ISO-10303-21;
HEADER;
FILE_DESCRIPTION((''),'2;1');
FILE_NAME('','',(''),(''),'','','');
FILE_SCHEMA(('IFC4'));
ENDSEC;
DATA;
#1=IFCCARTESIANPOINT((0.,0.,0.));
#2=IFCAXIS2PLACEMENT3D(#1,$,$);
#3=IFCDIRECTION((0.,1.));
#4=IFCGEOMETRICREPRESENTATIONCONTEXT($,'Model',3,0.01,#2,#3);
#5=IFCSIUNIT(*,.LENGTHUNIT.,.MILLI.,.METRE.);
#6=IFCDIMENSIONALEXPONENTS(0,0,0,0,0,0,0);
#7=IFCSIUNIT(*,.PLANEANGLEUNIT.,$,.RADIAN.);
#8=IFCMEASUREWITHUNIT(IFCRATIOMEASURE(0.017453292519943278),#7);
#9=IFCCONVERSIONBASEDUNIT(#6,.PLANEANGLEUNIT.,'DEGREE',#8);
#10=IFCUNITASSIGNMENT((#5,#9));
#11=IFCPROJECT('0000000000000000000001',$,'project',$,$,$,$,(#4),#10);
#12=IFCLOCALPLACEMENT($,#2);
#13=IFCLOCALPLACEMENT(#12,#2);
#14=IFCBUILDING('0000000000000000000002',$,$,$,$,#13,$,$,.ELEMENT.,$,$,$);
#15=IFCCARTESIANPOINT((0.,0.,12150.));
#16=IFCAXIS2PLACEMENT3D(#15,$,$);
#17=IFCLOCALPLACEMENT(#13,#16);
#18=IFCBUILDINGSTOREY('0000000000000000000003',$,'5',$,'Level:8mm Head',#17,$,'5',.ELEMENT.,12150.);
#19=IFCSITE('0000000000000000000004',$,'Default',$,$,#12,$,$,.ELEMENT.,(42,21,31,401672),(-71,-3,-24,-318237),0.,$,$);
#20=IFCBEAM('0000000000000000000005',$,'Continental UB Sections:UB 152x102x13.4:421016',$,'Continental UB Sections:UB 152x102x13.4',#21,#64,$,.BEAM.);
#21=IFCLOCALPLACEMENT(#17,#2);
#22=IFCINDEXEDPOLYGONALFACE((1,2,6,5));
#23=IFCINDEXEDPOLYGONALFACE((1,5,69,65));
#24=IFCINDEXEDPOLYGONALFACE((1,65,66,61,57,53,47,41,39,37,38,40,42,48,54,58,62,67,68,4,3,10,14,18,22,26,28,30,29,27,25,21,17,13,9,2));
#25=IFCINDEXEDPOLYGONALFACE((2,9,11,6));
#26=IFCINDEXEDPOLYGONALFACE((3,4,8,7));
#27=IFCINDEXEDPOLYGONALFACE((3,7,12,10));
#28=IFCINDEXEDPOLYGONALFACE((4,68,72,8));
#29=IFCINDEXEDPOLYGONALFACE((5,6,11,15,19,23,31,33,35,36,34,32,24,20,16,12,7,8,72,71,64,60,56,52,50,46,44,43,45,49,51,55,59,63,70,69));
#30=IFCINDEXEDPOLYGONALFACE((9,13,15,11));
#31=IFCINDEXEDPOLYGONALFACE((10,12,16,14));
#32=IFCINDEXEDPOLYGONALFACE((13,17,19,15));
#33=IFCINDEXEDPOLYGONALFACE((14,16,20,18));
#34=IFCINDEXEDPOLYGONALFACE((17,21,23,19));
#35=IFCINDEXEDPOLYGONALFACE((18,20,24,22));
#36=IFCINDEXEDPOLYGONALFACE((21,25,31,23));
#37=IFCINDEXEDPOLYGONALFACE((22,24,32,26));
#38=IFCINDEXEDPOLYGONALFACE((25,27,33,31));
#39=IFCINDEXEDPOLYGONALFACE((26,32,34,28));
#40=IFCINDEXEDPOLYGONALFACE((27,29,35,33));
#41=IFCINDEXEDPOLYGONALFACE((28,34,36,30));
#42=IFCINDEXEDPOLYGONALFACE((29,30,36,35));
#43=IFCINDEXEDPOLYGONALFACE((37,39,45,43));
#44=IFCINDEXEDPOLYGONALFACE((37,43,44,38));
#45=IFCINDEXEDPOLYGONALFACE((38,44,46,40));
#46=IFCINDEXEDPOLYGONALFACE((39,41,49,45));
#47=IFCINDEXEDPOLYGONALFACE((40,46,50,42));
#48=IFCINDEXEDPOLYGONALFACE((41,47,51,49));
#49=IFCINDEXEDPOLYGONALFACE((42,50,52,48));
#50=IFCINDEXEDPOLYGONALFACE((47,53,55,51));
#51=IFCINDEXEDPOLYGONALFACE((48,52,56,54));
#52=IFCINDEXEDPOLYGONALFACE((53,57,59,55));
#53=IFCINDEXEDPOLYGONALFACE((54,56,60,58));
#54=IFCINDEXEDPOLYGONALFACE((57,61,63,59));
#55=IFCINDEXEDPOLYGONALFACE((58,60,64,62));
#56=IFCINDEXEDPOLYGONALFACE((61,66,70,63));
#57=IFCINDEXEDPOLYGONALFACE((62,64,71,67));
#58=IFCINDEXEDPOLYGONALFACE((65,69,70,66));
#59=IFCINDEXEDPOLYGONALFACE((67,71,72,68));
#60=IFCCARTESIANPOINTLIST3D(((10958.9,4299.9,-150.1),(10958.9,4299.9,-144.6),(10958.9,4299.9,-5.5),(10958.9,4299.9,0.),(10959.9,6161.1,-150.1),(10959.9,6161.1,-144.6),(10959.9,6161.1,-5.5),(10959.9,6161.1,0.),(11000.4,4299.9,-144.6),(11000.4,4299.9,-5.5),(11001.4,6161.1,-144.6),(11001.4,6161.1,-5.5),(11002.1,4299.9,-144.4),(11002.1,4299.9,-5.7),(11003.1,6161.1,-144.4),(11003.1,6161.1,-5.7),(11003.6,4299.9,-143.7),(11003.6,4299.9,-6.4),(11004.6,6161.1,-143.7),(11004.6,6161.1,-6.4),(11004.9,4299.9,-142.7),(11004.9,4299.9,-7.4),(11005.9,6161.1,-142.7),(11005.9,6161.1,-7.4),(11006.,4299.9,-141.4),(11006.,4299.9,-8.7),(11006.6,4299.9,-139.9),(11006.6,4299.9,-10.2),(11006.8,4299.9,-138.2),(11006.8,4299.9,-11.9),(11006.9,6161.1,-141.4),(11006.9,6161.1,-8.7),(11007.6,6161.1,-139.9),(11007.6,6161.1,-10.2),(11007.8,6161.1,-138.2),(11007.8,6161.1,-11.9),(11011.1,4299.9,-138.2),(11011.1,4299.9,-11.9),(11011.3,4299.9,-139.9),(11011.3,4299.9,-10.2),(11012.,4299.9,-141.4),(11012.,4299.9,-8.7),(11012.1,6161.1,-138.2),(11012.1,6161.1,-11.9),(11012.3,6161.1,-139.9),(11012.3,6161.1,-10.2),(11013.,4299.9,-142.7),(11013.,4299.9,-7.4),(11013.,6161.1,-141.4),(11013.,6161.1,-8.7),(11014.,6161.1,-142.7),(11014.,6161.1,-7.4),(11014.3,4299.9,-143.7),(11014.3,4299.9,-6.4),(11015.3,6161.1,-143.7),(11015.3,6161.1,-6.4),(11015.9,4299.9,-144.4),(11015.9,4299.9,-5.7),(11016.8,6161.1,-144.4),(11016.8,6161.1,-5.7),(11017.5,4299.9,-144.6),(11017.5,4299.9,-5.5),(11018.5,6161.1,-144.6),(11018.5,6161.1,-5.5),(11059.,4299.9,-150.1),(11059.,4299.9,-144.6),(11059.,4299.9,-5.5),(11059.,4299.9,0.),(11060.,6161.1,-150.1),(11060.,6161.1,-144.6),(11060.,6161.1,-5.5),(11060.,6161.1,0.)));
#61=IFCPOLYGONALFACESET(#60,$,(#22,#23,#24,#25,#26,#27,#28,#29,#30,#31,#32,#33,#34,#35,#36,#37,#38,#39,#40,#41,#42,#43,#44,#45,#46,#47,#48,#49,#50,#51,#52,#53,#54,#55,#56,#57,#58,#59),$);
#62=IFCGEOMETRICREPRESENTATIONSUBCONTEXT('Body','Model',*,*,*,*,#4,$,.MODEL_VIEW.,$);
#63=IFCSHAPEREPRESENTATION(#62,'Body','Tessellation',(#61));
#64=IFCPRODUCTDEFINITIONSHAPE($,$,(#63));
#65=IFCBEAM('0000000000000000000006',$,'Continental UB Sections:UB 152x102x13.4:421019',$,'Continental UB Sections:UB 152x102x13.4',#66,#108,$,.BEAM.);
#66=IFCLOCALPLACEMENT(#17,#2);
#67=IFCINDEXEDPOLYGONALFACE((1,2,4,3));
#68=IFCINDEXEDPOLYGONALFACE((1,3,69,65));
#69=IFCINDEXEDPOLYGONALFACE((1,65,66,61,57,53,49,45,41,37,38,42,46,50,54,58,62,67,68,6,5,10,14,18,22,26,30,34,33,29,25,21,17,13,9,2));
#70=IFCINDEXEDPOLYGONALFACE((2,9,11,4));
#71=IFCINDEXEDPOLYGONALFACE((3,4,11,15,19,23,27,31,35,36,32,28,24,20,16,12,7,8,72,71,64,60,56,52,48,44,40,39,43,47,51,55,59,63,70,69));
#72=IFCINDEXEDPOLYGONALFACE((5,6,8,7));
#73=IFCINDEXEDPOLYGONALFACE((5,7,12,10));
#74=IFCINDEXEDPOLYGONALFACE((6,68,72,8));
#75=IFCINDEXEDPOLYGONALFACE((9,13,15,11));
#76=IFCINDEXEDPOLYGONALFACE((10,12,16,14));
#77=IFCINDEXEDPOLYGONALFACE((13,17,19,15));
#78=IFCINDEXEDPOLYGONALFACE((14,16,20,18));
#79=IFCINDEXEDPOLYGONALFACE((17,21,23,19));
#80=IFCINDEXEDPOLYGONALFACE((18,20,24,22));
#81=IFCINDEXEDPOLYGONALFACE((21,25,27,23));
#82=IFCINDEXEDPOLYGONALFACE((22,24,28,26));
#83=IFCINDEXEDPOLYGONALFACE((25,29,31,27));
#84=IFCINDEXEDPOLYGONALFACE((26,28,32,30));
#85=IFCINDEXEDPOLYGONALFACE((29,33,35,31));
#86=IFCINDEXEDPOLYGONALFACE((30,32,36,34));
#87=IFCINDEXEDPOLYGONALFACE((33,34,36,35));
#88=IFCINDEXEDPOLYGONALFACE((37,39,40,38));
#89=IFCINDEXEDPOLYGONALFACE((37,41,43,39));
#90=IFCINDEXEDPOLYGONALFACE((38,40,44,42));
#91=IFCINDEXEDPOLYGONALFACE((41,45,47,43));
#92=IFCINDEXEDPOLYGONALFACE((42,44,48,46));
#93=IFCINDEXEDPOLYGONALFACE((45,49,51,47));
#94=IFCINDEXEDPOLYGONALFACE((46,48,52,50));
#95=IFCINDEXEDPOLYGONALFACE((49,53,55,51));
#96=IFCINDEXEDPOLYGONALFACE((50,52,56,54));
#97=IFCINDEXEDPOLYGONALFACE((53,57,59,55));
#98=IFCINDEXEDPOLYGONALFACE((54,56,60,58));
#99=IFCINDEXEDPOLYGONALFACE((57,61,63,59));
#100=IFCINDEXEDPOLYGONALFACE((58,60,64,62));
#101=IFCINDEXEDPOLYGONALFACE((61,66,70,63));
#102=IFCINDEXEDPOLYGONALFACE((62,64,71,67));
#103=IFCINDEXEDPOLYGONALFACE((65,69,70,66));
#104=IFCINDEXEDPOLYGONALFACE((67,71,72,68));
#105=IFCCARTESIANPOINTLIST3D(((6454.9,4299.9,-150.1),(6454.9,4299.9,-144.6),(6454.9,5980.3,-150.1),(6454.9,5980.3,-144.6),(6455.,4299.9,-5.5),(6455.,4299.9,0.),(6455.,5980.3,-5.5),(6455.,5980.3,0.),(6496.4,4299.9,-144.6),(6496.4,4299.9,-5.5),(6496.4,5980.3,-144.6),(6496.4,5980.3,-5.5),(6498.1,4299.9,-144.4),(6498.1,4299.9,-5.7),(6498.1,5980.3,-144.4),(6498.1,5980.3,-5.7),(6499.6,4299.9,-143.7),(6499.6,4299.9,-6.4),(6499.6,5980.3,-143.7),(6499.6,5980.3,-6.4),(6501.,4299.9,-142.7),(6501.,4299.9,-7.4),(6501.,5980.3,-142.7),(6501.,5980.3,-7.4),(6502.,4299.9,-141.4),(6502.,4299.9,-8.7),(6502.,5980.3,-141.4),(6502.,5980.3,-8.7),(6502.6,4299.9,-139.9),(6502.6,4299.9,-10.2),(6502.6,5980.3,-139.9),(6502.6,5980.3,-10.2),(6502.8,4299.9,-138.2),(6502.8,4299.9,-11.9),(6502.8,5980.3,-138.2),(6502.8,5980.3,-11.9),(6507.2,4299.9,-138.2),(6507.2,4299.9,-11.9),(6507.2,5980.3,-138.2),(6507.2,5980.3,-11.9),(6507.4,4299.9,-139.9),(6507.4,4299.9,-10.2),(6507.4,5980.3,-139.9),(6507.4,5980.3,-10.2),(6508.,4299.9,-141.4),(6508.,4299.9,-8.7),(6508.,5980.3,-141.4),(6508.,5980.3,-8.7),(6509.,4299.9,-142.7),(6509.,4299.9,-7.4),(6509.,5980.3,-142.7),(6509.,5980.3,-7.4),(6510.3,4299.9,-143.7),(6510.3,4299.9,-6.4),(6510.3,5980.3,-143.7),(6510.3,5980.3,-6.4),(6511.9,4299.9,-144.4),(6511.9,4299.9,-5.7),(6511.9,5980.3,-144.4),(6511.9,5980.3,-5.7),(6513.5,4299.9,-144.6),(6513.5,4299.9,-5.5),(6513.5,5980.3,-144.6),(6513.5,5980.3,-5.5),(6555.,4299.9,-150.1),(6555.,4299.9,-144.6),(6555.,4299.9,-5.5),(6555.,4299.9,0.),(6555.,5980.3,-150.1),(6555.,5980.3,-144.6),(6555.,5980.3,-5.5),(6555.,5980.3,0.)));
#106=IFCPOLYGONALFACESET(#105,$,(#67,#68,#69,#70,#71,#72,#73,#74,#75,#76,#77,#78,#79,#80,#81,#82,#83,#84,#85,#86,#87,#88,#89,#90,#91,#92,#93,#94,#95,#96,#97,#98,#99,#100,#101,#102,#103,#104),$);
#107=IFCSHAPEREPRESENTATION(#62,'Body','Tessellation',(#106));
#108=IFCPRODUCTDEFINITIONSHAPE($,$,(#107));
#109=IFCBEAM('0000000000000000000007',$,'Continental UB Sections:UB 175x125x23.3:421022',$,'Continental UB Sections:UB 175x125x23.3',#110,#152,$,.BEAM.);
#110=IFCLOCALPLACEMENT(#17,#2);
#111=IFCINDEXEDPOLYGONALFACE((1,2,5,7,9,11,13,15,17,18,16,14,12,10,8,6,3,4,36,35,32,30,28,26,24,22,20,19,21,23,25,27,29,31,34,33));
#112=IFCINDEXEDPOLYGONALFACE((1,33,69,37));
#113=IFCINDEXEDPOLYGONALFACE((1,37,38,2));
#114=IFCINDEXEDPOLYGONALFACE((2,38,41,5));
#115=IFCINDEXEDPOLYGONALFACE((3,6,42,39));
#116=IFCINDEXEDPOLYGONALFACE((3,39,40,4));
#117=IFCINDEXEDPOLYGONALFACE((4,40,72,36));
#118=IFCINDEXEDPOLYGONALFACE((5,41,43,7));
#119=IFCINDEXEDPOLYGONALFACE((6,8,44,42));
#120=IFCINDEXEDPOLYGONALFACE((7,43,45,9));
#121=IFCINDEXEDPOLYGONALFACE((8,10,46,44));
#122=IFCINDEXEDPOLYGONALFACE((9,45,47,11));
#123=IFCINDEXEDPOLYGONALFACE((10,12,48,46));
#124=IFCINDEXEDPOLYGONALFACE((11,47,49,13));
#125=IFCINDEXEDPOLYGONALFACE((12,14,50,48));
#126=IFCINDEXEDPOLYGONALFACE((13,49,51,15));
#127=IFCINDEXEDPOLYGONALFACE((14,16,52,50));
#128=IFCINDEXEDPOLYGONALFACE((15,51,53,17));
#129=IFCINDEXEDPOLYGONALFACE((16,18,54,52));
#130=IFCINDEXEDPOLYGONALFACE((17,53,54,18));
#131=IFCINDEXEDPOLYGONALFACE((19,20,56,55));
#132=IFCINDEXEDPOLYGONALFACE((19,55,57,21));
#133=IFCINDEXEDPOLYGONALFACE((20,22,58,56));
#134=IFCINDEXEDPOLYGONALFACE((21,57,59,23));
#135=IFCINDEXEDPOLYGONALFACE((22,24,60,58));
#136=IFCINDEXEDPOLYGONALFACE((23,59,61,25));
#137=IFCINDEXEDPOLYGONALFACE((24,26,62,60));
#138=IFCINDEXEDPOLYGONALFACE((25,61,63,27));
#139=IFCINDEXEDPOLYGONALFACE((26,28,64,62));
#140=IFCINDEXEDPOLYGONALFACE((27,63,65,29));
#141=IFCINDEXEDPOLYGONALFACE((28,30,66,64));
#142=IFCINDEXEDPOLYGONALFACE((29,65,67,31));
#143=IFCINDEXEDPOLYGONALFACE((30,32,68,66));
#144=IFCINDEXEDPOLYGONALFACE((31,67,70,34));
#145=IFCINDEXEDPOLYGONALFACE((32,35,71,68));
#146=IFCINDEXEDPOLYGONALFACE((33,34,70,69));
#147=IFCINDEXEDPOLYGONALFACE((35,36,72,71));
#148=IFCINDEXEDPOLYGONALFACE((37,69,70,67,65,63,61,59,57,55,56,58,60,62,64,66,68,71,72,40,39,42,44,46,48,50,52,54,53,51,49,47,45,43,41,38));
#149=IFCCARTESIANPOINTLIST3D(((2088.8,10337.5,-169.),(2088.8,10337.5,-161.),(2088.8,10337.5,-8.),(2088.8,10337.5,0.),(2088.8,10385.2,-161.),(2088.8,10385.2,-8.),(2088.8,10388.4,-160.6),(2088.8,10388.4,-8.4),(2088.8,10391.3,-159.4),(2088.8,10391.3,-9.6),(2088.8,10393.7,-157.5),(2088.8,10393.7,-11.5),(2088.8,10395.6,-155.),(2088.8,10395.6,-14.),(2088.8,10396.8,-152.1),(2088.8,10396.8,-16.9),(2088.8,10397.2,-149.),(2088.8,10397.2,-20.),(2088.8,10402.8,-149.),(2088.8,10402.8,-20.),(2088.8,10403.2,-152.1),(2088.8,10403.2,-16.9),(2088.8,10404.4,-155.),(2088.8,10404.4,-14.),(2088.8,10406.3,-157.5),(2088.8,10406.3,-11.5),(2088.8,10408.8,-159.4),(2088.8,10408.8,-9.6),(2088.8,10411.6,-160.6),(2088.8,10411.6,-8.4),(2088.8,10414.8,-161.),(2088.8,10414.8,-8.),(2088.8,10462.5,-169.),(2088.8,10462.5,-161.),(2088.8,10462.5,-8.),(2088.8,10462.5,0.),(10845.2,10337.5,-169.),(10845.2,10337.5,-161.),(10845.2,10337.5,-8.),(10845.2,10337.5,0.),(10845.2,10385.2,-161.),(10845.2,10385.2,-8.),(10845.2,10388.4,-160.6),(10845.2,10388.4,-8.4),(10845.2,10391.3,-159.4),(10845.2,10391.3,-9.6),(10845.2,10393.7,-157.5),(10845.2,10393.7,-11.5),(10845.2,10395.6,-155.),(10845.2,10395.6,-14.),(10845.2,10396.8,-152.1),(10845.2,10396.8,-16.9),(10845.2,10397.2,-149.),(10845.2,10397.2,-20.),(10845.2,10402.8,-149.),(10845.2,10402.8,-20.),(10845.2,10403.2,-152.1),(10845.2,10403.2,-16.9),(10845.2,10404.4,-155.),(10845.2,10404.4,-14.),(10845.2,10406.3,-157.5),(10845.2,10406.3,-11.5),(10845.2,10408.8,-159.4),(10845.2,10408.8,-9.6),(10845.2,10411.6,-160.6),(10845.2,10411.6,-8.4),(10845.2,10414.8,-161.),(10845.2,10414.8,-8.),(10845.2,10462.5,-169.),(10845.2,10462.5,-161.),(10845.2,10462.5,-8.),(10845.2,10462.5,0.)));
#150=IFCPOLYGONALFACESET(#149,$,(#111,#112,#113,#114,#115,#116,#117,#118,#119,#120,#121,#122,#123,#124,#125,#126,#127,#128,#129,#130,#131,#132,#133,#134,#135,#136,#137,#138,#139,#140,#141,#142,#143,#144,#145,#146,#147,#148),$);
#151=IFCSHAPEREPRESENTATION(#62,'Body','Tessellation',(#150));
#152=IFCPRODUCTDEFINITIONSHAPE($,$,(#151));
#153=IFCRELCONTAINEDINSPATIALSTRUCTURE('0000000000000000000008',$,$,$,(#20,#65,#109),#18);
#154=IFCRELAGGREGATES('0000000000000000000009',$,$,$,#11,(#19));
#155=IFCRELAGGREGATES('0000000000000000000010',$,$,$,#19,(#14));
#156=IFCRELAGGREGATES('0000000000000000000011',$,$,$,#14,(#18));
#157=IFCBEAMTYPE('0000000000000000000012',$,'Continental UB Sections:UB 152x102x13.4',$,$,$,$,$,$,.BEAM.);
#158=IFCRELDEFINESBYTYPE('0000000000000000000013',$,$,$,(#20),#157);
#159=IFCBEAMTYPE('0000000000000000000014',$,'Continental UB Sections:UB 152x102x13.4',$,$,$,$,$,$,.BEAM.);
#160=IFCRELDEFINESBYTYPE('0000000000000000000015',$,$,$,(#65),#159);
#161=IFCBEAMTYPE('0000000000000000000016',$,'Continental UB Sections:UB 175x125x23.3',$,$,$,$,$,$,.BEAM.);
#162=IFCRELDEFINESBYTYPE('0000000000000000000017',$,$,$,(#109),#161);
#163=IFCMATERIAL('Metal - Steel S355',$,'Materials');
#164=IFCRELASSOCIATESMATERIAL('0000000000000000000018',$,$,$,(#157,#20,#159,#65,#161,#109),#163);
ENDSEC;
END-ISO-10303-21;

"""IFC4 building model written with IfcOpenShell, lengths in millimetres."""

from ifc_helpers import new_model, entity, si_unit, converted_unit, direction, frame, origin, place, context, subcontext, project, spatial, line, arc, indexed_curve, outline, extrude, source, transform, mapped, material, type_object, type_shapes, element, save


model = new_model("IFC4")

# Units and contexts
model_context = context("Model", 3, precision=0.01, world=origin(), true_north=direction((0.0, 1.0)))
body_context = subcontext(model_context, "Body", "Model", "MODEL_VIEW")
ifc_project = project(units=[si_unit("LENGTHUNIT", "METRE", prefix="MILLI"), converted_unit("PLANEANGLEUNIT", "DEGREE", entity("IfcRatioMeasure", 0.017453292519943278), si_unit("PLANEANGLEUNIT", "RADIAN"), dimensions=[0, 0, 0, 0, 0, 0, 0])], contexts=[model_context])

# Site, building, storey
site_placement = place(None, origin())
site = spatial("IfcSite", under=ifc_project, at=site_placement, Name="Default", CompositionType="ELEMENT", RefLatitude=(42, 21, 31, 401672), RefLongitude=(-71, -3, -24, -318237), RefElevation=0.0)
building_placement = place(site_placement, origin())
building = spatial("IfcBuilding", under=site, at=building_placement, CompositionType="ELEMENT")
storey_placement = place(building_placement, frame((0.0, 0.0, 12150.0)))
storey = spatial("IfcBuildingStorey", under=building, at=storey_placement, Name="5", ObjectType="Level:8mm Head", LongName="5", CompositionType="ELEMENT", Elevation=12150.0)

# Beams
ifc_material = material(Name="Metal - Steel S355", Category="Materials")
beam_type_1 = type_object("IfcBeamType", Name="Continental UB Sections:UB 152x102x13.4", PredefinedType="BEAM", material=ifc_material)
shared_shape_1 = source(origin(), body_context, "Body", "SweptSolid", [
    extrude(outline(indexed_curve([(-75.0, -50.1), (-69.6, -50.1), (-69.6, -8.5), (-67.7, -4.0), (-63.2, -2.1), (63.1, -2.1), (67.7, -4.0), (69.5, -8.5), (69.5, -50.1), (75.1, -50.1), (75.1, 50.1), (69.5, 50.1), (69.5, 8.6), (67.7, 4.0), (63.1, 2.2), (-63.2, 2.2), (-67.7, 4.0), (-69.6, 8.6), (-69.6, 50.0), (-75.0, 50.0)], segments=[line(1, 2, 3), arc(3, 4, 5), line(5, 6), arc(6, 7, 8), line(8, 9, 10, 11, 12, 13), arc(13, 14, 15), line(15, 16), arc(16, 17, 18), line(18, 19, 20, 1)], self_intersect=False)), frame((-1000.1, 0.0, 0.0), z_axis=(1.0, 0.0, 0.0), x_axis=(0.0, 0.0, -1.0)), (0.0, 0.0, 1.0), 1861.2),
])
type_shapes(beam_type_1, [shared_shape_1])
beam_1_placement = place(storey_placement, frame((11009.5, 5300.0, -75.1), z_axis=(0.0, 0.0, 1.0), x_axis=(0.000526, 1.0, 0.0)))
element("IfcBeam", 1, at=beam_1_placement, inside=storey, type_object=beam_type_1, material=ifc_material, Name="Continental UB Sections:UB 152x102x13.4:421016", ObjectType="Continental UB Sections:UB 152x102x13.4", PredefinedType="BEAM", context=body_context, shape_type="MappedRepresentation", body=[
    mapped(shared_shape_1, transform((0.0, 0.0, 0.0), scale=1.0)),
])
beam_type_2 = type_object("IfcBeamType", Name="Continental UB Sections:UB 152x102x13.4", PredefinedType="BEAM", material=ifc_material)
shared_shape_2 = source(origin(), body_context, "Body", "SweptSolid", [
    extrude(outline(indexed_curve([(-75.0, -50.1), (-69.6, -50.1), (-69.6, -8.5), (-67.7, -4.0), (-63.2, -2.1), (63.1, -2.1), (67.7, -4.0), (69.5, -8.5), (69.5, -50.1), (75.1, -50.1), (75.1, 50.1), (69.5, 50.1), (69.5, 8.6), (67.7, 4.0), (63.1, 2.2), (-63.2, 2.2), (-67.7, 4.0), (-69.6, 8.6), (-69.6, 50.0), (-75.0, 50.0)], segments=[line(1, 2, 3), arc(3, 4, 5), line(5, 6), arc(6, 7, 8), line(8, 9, 10, 11, 12, 13), arc(13, 14, 15), line(15, 16), arc(16, 17, 18), line(18, 19, 20, 1)], self_intersect=False)), frame((-1000.1, 0.0, 0.0), z_axis=(1.0, 0.0, 0.0), x_axis=(0.0, 0.0, -1.0)), (0.0, 0.0, 1.0), 1680.4),
])
type_shapes(beam_type_2, [shared_shape_2])
beam_2_placement = place(storey_placement, frame((6505.0, 5300.0, -75.1), z_axis=(0.0, 0.0, 1.0), x_axis=(0.0, 1.0, 0.0)))
element("IfcBeam", 2, at=beam_2_placement, inside=storey, type_object=beam_type_2, material=ifc_material, Name="Continental UB Sections:UB 152x102x13.4:421019", ObjectType="Continental UB Sections:UB 152x102x13.4", PredefinedType="BEAM", context=body_context, shape_type="MappedRepresentation", body=[
    mapped(shared_shape_2, transform((0.0, 0.0, 0.0), scale=1.0)),
])
beam_type_3 = type_object("IfcBeamType", Name="Continental UB Sections:UB 175x125x23.3", PredefinedType="BEAM", material=ifc_material)
shared_shape_3 = source(origin(), body_context, "Body", "SweptSolid", [
    extrude(outline(indexed_curve([(-84.5, -62.5), (-76.5, -62.5), (-76.5, -14.8), (-73.0, -6.3), (-64.5, -2.7), (64.5, -2.7), (73.0, -6.3), (76.5, -14.7), (76.5, -62.5), (84.5, -62.5), (84.5, 62.5), (76.5, 62.5), (76.5, 14.8), (73.0, 6.3), (64.5, 2.8), (-64.5, 2.8), (-73.0, 6.3), (-76.5, 14.8), (-76.5, 62.5), (-84.5, 62.5)], segments=[line(1, 2, 3), arc(3, 4, 5), line(5, 6), arc(6, 7, 8), line(8, 9, 10, 11, 12, 13), arc(13, 14, 15), line(15, 16), arc(16, 17, 18), line(18, 19, 20, 1)], self_intersect=False)), frame((-4416.2, 0.0, 0.0), z_axis=(1.0, 0.0, 0.0), x_axis=(0.0, 0.0, -1.0)), (0.0, 0.0, 1.0), 8756.4),
])
type_shapes(beam_type_3, [shared_shape_3])
for number, where, name in (
    (3, (6505.0, 10400.0, -84.5), "Continental UB Sections:UB 175x125x23.3:421022"),
):
    element("IfcBeam", number, at=place(storey_placement, frame(where)), inside=storey, type_object=beam_type_3, material=ifc_material, Name=name, ObjectType="Continental UB Sections:UB 175x125x23.3", PredefinedType="BEAM", context=body_context, shape_type="MappedRepresentation", body=[
        mapped(shared_shape_3, transform((0.0, 0.0, 0.0), scale=1.0)),
    ])

save(model, "model.ifc")
